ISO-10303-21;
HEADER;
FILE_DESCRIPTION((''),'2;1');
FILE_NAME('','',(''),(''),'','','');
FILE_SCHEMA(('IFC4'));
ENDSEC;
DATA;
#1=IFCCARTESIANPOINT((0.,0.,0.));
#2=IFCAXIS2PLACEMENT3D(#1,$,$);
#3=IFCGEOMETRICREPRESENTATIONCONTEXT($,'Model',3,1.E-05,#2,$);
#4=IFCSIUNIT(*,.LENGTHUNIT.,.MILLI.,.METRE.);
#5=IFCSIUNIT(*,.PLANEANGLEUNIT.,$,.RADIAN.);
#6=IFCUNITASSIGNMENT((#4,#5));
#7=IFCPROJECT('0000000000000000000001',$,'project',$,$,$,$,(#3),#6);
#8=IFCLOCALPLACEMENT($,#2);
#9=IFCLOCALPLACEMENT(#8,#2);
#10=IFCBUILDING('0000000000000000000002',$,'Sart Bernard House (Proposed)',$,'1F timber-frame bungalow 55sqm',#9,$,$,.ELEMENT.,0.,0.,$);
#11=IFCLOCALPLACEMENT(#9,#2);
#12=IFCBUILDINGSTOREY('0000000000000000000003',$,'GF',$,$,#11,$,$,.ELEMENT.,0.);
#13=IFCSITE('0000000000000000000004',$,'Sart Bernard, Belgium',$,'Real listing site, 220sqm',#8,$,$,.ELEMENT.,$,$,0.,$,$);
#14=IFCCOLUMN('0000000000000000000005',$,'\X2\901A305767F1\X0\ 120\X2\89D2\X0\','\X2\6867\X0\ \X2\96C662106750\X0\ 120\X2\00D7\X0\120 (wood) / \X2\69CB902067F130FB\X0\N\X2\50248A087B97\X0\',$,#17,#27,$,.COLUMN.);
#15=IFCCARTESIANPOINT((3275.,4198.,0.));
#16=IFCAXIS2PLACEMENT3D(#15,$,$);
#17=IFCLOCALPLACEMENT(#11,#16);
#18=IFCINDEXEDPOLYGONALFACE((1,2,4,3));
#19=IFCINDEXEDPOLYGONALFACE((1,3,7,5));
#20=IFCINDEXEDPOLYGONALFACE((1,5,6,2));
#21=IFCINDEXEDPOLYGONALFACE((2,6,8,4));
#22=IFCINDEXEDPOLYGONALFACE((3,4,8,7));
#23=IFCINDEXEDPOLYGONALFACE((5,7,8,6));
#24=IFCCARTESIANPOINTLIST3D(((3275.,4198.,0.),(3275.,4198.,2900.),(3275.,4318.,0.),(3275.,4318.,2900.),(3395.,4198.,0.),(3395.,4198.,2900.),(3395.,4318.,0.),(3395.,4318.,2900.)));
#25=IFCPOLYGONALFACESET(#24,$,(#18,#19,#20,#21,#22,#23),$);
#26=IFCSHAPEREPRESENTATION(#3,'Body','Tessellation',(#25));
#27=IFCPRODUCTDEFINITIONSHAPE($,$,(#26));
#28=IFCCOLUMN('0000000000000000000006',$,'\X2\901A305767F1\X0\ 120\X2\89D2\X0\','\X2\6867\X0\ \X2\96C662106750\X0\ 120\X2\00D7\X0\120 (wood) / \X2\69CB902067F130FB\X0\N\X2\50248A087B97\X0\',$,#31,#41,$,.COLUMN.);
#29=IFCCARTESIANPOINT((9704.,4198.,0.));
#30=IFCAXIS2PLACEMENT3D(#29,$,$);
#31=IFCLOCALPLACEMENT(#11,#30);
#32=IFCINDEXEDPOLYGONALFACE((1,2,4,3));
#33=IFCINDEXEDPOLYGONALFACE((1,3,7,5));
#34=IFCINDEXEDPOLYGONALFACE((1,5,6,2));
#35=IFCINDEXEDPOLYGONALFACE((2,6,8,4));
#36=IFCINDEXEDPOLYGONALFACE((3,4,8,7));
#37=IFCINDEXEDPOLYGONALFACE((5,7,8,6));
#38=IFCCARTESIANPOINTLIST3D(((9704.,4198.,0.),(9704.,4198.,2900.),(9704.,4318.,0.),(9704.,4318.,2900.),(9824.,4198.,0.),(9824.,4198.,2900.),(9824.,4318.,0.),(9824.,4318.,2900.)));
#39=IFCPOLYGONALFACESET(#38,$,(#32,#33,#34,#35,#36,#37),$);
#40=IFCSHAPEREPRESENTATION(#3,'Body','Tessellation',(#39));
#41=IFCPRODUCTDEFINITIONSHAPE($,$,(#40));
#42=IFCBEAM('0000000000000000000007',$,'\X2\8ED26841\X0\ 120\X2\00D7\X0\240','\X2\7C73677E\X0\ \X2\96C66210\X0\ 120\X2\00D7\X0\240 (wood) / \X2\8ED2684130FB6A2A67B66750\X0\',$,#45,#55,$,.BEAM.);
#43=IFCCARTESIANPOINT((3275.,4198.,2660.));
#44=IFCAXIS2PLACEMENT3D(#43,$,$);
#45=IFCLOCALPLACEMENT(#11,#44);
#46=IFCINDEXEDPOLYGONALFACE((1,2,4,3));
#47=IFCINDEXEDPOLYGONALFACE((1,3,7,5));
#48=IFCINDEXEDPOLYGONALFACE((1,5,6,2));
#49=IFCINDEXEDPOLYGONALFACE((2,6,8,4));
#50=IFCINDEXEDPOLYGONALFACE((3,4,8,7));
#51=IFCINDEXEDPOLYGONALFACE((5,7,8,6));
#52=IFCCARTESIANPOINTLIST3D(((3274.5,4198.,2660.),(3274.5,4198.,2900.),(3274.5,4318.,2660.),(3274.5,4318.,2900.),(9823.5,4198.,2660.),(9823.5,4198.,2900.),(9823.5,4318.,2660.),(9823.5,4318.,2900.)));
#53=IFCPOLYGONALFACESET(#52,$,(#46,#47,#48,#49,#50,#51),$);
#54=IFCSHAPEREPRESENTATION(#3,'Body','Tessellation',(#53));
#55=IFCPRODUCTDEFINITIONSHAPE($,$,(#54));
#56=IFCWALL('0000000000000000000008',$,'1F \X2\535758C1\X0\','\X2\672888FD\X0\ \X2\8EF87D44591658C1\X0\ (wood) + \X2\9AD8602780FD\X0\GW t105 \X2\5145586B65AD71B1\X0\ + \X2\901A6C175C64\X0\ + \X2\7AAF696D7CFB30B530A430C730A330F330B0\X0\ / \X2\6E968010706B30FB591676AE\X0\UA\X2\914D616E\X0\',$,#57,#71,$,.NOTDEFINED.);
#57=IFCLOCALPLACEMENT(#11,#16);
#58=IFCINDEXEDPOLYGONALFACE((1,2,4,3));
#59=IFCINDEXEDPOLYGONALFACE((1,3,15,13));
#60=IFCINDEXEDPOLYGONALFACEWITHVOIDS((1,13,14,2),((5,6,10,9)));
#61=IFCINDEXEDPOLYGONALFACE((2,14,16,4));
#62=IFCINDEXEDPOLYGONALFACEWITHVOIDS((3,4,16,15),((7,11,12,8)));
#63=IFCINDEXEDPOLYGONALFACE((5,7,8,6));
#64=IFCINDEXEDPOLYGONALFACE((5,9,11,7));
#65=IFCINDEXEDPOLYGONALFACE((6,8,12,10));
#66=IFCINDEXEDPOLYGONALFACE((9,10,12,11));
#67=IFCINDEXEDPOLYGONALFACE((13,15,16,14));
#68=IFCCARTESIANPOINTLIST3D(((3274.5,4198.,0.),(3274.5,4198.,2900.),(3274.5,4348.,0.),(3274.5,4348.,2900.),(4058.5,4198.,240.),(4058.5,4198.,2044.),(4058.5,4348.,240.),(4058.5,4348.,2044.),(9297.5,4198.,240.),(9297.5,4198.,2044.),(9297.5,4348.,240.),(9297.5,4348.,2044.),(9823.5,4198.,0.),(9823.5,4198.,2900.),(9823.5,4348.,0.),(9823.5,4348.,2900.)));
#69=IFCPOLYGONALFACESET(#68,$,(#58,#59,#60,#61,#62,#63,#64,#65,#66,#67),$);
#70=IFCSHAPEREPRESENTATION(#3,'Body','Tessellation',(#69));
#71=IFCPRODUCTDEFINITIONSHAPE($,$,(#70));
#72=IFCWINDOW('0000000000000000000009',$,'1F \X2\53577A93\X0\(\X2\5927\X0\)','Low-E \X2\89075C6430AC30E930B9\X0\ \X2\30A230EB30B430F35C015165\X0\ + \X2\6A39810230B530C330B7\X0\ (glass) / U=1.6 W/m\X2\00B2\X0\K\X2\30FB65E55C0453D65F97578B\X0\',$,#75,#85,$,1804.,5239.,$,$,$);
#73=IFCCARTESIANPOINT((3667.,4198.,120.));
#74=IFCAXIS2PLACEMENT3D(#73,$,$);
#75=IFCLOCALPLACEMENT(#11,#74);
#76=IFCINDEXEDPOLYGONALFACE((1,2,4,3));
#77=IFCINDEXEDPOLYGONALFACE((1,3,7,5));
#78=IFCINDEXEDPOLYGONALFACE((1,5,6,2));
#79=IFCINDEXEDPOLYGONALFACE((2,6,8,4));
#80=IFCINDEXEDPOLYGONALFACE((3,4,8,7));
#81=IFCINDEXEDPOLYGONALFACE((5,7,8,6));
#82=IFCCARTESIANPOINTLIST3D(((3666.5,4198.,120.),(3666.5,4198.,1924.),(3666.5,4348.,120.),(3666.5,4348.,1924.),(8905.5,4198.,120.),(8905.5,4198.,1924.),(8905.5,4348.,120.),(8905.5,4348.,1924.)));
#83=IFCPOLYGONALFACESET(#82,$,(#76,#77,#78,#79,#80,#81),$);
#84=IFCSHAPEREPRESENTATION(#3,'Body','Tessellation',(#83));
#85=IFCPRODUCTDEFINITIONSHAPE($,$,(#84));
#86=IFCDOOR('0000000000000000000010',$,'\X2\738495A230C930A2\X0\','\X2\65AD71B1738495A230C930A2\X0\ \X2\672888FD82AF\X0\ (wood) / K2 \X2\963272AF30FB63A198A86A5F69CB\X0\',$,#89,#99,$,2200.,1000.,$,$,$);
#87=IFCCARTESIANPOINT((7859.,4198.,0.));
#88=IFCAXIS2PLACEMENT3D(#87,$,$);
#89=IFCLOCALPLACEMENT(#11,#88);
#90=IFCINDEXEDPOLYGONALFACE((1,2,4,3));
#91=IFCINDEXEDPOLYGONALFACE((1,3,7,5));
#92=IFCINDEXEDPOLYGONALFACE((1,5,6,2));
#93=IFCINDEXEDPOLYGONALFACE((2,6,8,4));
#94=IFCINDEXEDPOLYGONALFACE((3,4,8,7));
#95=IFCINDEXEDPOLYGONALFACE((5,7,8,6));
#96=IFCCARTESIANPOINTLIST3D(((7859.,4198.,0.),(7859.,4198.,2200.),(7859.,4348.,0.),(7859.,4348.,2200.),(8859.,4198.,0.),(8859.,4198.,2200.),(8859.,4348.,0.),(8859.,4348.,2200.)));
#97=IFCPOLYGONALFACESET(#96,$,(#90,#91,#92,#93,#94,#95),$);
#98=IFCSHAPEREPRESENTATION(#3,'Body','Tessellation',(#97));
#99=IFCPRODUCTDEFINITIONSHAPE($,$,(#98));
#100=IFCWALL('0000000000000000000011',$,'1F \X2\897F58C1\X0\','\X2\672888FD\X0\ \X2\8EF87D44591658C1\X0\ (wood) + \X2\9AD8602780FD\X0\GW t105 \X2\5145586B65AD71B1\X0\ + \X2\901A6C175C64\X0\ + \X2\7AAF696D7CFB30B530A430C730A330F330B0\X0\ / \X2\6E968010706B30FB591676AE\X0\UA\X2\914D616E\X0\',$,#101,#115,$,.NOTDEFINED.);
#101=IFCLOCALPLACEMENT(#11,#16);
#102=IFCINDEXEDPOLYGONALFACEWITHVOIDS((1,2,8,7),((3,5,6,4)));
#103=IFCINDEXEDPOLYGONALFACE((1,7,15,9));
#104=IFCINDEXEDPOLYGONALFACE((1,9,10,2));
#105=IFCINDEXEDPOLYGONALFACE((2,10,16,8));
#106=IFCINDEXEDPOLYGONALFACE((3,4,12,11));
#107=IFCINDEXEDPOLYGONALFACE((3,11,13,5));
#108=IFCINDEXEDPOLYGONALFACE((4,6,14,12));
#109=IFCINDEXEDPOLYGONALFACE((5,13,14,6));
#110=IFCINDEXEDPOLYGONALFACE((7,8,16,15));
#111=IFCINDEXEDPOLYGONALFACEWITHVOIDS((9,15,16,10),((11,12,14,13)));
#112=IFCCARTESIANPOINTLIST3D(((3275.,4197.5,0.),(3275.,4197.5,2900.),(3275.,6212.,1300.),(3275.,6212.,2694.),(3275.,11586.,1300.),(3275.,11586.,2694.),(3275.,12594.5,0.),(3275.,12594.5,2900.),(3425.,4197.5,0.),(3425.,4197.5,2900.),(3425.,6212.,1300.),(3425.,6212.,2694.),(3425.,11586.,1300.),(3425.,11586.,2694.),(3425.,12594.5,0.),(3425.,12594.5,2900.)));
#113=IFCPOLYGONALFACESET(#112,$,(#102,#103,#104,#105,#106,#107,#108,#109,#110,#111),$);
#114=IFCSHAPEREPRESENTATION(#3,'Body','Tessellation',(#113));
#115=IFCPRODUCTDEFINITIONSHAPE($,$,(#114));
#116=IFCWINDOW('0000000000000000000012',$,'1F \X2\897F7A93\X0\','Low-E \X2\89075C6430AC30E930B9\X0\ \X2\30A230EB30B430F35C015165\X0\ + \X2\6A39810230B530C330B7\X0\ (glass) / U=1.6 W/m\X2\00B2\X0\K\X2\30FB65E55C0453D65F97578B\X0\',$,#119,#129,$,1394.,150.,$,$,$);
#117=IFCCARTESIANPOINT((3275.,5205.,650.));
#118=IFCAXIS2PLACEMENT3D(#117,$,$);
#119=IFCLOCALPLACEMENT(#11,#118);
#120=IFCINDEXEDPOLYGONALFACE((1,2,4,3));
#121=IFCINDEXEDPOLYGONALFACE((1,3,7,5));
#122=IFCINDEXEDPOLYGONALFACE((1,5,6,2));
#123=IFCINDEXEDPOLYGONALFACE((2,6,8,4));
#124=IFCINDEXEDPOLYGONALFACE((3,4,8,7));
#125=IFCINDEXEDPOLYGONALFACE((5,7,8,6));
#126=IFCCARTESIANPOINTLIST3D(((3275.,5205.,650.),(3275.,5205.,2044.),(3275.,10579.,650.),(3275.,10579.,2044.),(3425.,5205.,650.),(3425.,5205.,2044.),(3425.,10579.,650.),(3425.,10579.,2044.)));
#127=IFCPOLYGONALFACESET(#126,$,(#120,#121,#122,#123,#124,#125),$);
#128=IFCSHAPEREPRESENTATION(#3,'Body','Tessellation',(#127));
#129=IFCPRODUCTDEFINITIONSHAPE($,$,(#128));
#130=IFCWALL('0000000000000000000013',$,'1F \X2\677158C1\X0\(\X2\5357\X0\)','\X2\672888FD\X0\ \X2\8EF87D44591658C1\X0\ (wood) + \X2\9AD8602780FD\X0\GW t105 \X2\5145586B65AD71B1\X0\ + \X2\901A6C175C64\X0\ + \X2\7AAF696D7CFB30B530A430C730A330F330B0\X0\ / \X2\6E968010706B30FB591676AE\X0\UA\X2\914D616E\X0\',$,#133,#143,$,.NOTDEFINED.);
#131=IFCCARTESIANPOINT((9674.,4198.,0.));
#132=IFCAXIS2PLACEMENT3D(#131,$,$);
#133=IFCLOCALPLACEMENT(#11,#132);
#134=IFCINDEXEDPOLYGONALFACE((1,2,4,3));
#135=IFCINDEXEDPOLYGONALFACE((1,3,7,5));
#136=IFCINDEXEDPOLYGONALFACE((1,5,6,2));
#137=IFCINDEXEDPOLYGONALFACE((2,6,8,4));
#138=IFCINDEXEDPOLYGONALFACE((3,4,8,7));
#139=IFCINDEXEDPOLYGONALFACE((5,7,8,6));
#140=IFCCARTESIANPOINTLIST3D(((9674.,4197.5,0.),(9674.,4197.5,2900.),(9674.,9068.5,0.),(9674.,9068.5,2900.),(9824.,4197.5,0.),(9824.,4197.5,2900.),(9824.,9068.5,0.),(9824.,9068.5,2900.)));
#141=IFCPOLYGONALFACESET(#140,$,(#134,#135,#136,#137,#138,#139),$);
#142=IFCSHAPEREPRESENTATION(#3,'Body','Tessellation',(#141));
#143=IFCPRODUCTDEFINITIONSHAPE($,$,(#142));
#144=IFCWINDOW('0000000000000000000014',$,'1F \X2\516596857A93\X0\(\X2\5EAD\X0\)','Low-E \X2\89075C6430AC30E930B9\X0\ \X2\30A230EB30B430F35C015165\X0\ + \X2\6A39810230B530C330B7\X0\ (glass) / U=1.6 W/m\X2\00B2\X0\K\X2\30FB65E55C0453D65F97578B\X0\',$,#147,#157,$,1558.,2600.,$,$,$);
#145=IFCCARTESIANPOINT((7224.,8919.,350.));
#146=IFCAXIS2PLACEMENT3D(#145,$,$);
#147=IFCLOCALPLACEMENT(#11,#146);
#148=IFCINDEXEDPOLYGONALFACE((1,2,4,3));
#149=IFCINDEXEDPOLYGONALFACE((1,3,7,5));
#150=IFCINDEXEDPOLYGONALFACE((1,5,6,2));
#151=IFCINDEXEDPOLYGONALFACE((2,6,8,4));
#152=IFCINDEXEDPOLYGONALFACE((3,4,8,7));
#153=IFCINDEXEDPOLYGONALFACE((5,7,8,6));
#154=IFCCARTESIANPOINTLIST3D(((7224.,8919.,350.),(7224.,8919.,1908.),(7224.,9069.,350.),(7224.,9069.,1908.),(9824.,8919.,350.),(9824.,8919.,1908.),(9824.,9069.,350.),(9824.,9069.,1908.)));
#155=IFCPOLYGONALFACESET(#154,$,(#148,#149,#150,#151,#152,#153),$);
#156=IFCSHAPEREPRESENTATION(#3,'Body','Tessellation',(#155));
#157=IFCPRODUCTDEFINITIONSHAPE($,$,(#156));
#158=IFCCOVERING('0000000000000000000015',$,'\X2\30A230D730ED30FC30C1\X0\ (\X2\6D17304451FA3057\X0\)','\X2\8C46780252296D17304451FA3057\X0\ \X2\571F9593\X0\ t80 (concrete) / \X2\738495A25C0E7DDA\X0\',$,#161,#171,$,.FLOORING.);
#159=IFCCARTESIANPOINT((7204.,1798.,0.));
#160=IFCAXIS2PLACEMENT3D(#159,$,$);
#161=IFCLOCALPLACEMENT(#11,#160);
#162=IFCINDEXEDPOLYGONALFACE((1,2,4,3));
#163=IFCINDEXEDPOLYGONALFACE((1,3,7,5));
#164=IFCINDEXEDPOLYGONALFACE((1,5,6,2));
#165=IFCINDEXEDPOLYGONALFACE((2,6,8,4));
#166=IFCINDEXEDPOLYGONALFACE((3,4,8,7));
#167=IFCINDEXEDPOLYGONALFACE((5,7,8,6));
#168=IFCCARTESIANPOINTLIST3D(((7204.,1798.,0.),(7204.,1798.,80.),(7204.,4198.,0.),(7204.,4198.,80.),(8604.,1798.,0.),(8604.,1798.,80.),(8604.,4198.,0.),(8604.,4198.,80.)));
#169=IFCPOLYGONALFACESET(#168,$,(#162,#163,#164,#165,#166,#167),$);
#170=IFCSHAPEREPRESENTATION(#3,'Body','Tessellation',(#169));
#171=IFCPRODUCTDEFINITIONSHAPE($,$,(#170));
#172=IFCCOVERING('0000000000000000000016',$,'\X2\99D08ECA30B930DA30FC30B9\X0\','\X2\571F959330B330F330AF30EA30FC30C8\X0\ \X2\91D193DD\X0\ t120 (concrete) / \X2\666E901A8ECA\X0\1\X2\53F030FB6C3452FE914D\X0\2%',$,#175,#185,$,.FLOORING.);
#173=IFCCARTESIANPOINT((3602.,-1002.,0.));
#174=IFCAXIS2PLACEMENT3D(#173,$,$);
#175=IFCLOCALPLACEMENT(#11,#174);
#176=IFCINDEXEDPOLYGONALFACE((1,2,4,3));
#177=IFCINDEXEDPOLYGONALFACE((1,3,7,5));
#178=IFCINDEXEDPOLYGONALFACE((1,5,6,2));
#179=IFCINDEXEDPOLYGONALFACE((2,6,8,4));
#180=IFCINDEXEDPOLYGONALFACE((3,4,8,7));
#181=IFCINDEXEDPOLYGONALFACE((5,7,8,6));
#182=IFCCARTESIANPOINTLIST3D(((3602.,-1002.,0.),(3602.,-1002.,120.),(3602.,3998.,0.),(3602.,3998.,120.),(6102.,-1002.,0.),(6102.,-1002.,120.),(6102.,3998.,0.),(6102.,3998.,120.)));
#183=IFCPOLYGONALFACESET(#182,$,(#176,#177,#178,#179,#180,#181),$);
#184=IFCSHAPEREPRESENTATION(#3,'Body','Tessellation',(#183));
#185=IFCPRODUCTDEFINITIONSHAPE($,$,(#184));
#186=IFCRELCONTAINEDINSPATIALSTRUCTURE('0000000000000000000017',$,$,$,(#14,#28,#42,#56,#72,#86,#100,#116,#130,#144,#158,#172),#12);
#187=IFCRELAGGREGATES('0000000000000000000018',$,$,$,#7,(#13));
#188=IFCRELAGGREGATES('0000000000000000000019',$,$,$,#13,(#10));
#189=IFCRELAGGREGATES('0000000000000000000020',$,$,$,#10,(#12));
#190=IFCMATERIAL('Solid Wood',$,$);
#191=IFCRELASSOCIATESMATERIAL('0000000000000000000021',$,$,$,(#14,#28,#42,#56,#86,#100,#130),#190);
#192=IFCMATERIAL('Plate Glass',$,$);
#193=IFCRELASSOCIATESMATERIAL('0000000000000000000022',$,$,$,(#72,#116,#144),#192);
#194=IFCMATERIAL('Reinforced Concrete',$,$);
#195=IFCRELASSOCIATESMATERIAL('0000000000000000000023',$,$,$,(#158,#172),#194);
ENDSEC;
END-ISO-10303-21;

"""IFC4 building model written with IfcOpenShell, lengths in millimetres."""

from ifc_helpers import new_model, si_unit, frame, frame_2d, origin, place, context, project, spatial, rectangle, extrude, material, element, fill, save


model = new_model("IFC4")

# Units and contexts
model_context = context("Model", 3, precision=1e-05, world=origin())
ifc_project = project(units=[si_unit("LENGTHUNIT", "METRE", prefix="MILLI"), si_unit("PLANEANGLEUNIT", "RADIAN")], contexts=[model_context])

# Site, building, storey
site_placement = place(None, origin())
site = spatial("IfcSite", under=ifc_project, at=site_placement, Name="Sart Bernard, Belgium", ObjectType="Real listing site, 220sqm", CompositionType="ELEMENT", RefElevation=0.0)
building_placement = place(site_placement, origin())
building = spatial("IfcBuilding", under=site, at=building_placement, Name="Sart Bernard House (Proposed)", ObjectType="1F timber-frame bungalow 55sqm", CompositionType="ELEMENT", ElevationOfRefHeight=0.0, ElevationOfTerrain=0.0)
storey_placement = place(building_placement, origin())
storey = spatial("IfcBuildingStorey", under=building, at=storey_placement, Name="GF", CompositionType="ELEMENT", Elevation=0.0)

# Columns
ifc_material_1 = material(Name="Solid Wood")
column_1_placement = place(storey_placement, frame((3275.0, 4198.0, 0.0)))
element("IfcColumn", 1, at=column_1_placement, inside=storey, material=ifc_material_1, Name="通し柱 120角", Description="桧 集成材 120×120 (wood) / 構造柱・N値計算", PredefinedType="COLUMN", context=model_context, shape_type="SweptSolid", body=[
    extrude(rectangle(XDim=120.0, YDim=120.0, at=frame_2d((60.0, 60.0))), frame((3275.0, 4198.0, 0.0)), (0.0, 0.0, 1.0), 2900.0),
])
column_2_placement = place(storey_placement, frame((9704.0, 4198.0, 0.0)))
element("IfcColumn", 2, at=column_2_placement, inside=storey, material=ifc_material_1, Name="通し柱 120角", Description="桧 集成材 120×120 (wood) / 構造柱・N値計算", PredefinedType="COLUMN", context=model_context, shape_type="SweptSolid", body=[
    extrude(rectangle(XDim=120.0, YDim=120.0, at=frame_2d((60.0, 60.0))), frame((9704.0, 4198.0, 0.0)), (0.0, 0.0, 1.0), 2900.0),
])

# Beam
beam_1_placement = place(storey_placement, frame((3275.0, 4198.0, 2660.0)))
element("IfcBeam", 3, at=beam_1_placement, inside=storey, material=ifc_material_1, Name="軒桁 120×240", Description="米松 集成 120×240 (wood) / 軒桁・横架材", PredefinedType="BEAM", context=model_context, shape_type="SweptSolid", body=[
    extrude(rectangle(XDim=6549.0, YDim=120.0, at=frame_2d((3274.0, 60.0))), frame((3275.0, 4198.0, 2660.0)), (0.0, 0.0, 1.0), 240.0),
])

# Shared definitions
ifc_material_2 = material(Name="Reinforced Concrete")

# Wall, openings, window, door
wall_1_placement = place(storey_placement, frame((3275.0, 4198.0, 0.0)))
wall_1 = element("IfcWall", 4, at=wall_1_placement, inside=storey, material=ifc_material_1, Name="1F 南壁", Description="木製 軸組外壁 (wood) + 高性能GW t105 充填断熱 + 通気層 + 窯業系サイディング / 準耐火・外皮UA配慮", PredefinedType="NOTDEFINED", context=model_context, shape_type="SweptSolid", body=[
    extrude(rectangle(XDim=6549.0, YDim=150.0, at=frame_2d((3274.0, 75.0))), frame((3275.0, 4198.0, 0.0)), (0.0, 0.0, 1.0), 2900.0),
])
opening_1_placement = place(storey_placement, frame((3667.0, 4198.0, 120.0)))
opening_1 = element("IfcOpeningElement", 5, at=opening_1_placement, cuts=wall_1, PredefinedType="NOTDEFINED", context=model_context, shape_type="SweptSolid", body=[
    extrude(rectangle(XDim=5239.0, YDim=150.0, at=frame_2d((2619.0, 75.0))), frame((3667.0, 4198.0, 120.0)), (0.0, 0.0, 1.0), 1804.0),
])
opening_2_placement = place(storey_placement, frame((7859.0, 4198.0, 0.0)))
opening_2 = element("IfcOpeningElement", 6, at=opening_2_placement, cuts=wall_1, PredefinedType="NOTDEFINED", context=model_context, shape_type="SweptSolid", body=[
    extrude(rectangle(XDim=1000.0, YDim=150.0, at=frame_2d((500.0, 75.0))), frame((7859.0, 4198.0, 0.0)), (0.0, 0.0, 1.0), 2200.0),
])
ifc_material_3 = material(Name="Plate Glass")
window_1_placement = place(storey_placement, frame((3667.0, 4198.0, 120.0)))
window_1 = element("IfcWindow", 7, at=window_1_placement, inside=storey, material=ifc_material_3, Name="1F 南窓(大)", Description="Low-E 複層ガラス アルゴン封入 + 樹脂サッシ (glass) / U=1.6 W/m²K・日射取得型", OverallHeight=1804.0, OverallWidth=5239.0, context=model_context, shape_type="SweptSolid", body=[
    extrude(rectangle(XDim=5239.0, YDim=150.0, at=frame_2d((2619.0, 75.0))), frame((3667.0, 4198.0, 120.0)), (0.0, 0.0, 1.0), 1804.0),
])
fill(opening_1, window_1)
door_1_placement = place(storey_placement, frame((7859.0, 4198.0, 0.0)))
door_1 = element("IfcDoor", 8, at=door_1_placement, inside=storey, material=ifc_material_1, Name="玄関ドア", Description="断熱玄関ドア 木製芯 (wood) / K2 防犯・採風機構", OverallHeight=2200.0, OverallWidth=1000.0, context=model_context, shape_type="SweptSolid", body=[
    extrude(rectangle(XDim=1000.0, YDim=150.0, at=frame_2d((500.0, 75.0))), frame((7859.0, 4198.0, 0.0)), (0.0, 0.0, 1.0), 2200.0),
])
fill(opening_2, door_1)

# Walls, openings, windows
wall_2_placement = place(storey_placement, frame((3275.0, 4198.0, 0.0)))
wall_2 = element("IfcWall", 9, at=wall_2_placement, inside=storey, material=ifc_material_1, Name="1F 西壁", Description="木製 軸組外壁 (wood) + 高性能GW t105 充填断熱 + 通気層 + 窯業系サイディング / 準耐火・外皮UA配慮", PredefinedType="NOTDEFINED", context=model_context, shape_type="SweptSolid", body=[
    extrude(rectangle(XDim=150.0, YDim=8397.0, at=frame_2d((75.0, 4198.0))), frame((3275.0, 4198.0, 0.0)), (0.0, 0.0, 1.0), 2900.0),
])
opening_3_placement = place(storey_placement, frame((3275.0, 5205.0, 650.0)))
opening_3 = element("IfcOpeningElement", 10, at=opening_3_placement, cuts=wall_2, PredefinedType="NOTDEFINED", context=model_context, shape_type="SweptSolid", body=[
    extrude(rectangle(XDim=150.0, YDim=5374.0, at=frame_2d((75.0, 2687.0))), frame((3275.0, 5205.0, 650.0)), (0.0, 0.0, 1.0), 1394.0),
])
window_2_placement = place(storey_placement, frame((3275.0, 5205.0, 650.0)))
window_2 = element("IfcWindow", 11, at=window_2_placement, inside=storey, material=ifc_material_3, Name="1F 西窓", Description="Low-E 複層ガラス アルゴン封入 + 樹脂サッシ (glass) / U=1.6 W/m²K・日射取得型", OverallHeight=1394.0, OverallWidth=150.0, context=model_context, shape_type="SweptSolid", body=[
    extrude(rectangle(XDim=150.0, YDim=5374.0, at=frame_2d((75.0, 2687.0))), frame((3275.0, 5205.0, 650.0)), (0.0, 0.0, 1.0), 1394.0),
])
fill(opening_3, window_2)
wall_3_placement = place(storey_placement, frame((9674.0, 4198.0, 0.0)))
wall_3 = element("IfcWall", 12, at=wall_3_placement, inside=storey, material=ifc_material_1, Name="1F 東壁(南)", Description="木製 軸組外壁 (wood) + 高性能GW t105 充填断熱 + 通気層 + 窯業系サイディング / 準耐火・外皮UA配慮", PredefinedType="NOTDEFINED", context=model_context, shape_type="SweptSolid", body=[
    extrude(rectangle(XDim=150.0, YDim=4871.0, at=frame_2d((75.0, 2435.0))), frame((9674.0, 4198.0, 0.0)), (0.0, 0.0, 1.0), 2900.0),
])
opening_4_placement = place(storey_placement, frame((7224.0, 8919.0, 350.0)))
opening_4 = element("IfcOpeningElement", 13, at=opening_4_placement, cuts=wall_3, PredefinedType="NOTDEFINED", context=model_context, shape_type="SweptSolid", body=[
    extrude(rectangle(XDim=2600.0, YDim=150.0, at=frame_2d((1300.0, 75.0))), frame((7224.0, 8919.0, 350.0)), (0.0, 0.0, 1.0), 1558.0),
])
window_3_placement = place(storey_placement, frame((7224.0, 8919.0, 350.0)))
window_3 = element("IfcWindow", 14, at=window_3_placement, inside=storey, material=ifc_material_3, Name="1F 入隅窓(庭)", Description="Low-E 複層ガラス アルゴン封入 + 樹脂サッシ (glass) / U=1.6 W/m²K・日射取得型", OverallHeight=1558.0, OverallWidth=2600.0, context=model_context, shape_type="SweptSolid", body=[
    extrude(rectangle(XDim=2600.0, YDim=150.0, at=frame_2d((1300.0, 75.0))), frame((7224.0, 8919.0, 350.0)), (0.0, 0.0, 1.0), 1558.0),
])
fill(opening_4, window_3)

# Coverings
covering_1_placement = place(storey_placement, frame((7204.0, 1798.0, 0.0)))
element("IfcCovering", 15, at=covering_1_placement, inside=storey, material=ifc_material_2, Name="アプローチ (洗い出し)", Description="豆砂利洗い出し 土間 t80 (concrete) / 玄関導線", PredefinedType="FLOORING", context=model_context, shape_type="SweptSolid", body=[
    extrude(rectangle(XDim=1400.0, YDim=2400.0, at=frame_2d((700.0, 1200.0))), frame((7204.0, 1798.0, 0.0)), (0.0, 0.0, 1.0), 80.0),
])
covering_2_placement = place(storey_placement, frame((3602.0, -1002.0, 0.0)))
element("IfcCovering", 16, at=covering_2_placement, inside=storey, material=ifc_material_2, Name="駐車スペース", Description="土間コンクリート 金鏝 t120 (concrete) / 普通車1台・水勾配2%", PredefinedType="FLOORING", context=model_context, shape_type="SweptSolid", body=[
    extrude(rectangle(XDim=2500.0, YDim=5000.0, at=frame_2d((1250.0, 2500.0))), frame((3602.0, -1002.0, 0.0)), (0.0, 0.0, 1.0), 120.0),
])

save(model, "model.ifc")
